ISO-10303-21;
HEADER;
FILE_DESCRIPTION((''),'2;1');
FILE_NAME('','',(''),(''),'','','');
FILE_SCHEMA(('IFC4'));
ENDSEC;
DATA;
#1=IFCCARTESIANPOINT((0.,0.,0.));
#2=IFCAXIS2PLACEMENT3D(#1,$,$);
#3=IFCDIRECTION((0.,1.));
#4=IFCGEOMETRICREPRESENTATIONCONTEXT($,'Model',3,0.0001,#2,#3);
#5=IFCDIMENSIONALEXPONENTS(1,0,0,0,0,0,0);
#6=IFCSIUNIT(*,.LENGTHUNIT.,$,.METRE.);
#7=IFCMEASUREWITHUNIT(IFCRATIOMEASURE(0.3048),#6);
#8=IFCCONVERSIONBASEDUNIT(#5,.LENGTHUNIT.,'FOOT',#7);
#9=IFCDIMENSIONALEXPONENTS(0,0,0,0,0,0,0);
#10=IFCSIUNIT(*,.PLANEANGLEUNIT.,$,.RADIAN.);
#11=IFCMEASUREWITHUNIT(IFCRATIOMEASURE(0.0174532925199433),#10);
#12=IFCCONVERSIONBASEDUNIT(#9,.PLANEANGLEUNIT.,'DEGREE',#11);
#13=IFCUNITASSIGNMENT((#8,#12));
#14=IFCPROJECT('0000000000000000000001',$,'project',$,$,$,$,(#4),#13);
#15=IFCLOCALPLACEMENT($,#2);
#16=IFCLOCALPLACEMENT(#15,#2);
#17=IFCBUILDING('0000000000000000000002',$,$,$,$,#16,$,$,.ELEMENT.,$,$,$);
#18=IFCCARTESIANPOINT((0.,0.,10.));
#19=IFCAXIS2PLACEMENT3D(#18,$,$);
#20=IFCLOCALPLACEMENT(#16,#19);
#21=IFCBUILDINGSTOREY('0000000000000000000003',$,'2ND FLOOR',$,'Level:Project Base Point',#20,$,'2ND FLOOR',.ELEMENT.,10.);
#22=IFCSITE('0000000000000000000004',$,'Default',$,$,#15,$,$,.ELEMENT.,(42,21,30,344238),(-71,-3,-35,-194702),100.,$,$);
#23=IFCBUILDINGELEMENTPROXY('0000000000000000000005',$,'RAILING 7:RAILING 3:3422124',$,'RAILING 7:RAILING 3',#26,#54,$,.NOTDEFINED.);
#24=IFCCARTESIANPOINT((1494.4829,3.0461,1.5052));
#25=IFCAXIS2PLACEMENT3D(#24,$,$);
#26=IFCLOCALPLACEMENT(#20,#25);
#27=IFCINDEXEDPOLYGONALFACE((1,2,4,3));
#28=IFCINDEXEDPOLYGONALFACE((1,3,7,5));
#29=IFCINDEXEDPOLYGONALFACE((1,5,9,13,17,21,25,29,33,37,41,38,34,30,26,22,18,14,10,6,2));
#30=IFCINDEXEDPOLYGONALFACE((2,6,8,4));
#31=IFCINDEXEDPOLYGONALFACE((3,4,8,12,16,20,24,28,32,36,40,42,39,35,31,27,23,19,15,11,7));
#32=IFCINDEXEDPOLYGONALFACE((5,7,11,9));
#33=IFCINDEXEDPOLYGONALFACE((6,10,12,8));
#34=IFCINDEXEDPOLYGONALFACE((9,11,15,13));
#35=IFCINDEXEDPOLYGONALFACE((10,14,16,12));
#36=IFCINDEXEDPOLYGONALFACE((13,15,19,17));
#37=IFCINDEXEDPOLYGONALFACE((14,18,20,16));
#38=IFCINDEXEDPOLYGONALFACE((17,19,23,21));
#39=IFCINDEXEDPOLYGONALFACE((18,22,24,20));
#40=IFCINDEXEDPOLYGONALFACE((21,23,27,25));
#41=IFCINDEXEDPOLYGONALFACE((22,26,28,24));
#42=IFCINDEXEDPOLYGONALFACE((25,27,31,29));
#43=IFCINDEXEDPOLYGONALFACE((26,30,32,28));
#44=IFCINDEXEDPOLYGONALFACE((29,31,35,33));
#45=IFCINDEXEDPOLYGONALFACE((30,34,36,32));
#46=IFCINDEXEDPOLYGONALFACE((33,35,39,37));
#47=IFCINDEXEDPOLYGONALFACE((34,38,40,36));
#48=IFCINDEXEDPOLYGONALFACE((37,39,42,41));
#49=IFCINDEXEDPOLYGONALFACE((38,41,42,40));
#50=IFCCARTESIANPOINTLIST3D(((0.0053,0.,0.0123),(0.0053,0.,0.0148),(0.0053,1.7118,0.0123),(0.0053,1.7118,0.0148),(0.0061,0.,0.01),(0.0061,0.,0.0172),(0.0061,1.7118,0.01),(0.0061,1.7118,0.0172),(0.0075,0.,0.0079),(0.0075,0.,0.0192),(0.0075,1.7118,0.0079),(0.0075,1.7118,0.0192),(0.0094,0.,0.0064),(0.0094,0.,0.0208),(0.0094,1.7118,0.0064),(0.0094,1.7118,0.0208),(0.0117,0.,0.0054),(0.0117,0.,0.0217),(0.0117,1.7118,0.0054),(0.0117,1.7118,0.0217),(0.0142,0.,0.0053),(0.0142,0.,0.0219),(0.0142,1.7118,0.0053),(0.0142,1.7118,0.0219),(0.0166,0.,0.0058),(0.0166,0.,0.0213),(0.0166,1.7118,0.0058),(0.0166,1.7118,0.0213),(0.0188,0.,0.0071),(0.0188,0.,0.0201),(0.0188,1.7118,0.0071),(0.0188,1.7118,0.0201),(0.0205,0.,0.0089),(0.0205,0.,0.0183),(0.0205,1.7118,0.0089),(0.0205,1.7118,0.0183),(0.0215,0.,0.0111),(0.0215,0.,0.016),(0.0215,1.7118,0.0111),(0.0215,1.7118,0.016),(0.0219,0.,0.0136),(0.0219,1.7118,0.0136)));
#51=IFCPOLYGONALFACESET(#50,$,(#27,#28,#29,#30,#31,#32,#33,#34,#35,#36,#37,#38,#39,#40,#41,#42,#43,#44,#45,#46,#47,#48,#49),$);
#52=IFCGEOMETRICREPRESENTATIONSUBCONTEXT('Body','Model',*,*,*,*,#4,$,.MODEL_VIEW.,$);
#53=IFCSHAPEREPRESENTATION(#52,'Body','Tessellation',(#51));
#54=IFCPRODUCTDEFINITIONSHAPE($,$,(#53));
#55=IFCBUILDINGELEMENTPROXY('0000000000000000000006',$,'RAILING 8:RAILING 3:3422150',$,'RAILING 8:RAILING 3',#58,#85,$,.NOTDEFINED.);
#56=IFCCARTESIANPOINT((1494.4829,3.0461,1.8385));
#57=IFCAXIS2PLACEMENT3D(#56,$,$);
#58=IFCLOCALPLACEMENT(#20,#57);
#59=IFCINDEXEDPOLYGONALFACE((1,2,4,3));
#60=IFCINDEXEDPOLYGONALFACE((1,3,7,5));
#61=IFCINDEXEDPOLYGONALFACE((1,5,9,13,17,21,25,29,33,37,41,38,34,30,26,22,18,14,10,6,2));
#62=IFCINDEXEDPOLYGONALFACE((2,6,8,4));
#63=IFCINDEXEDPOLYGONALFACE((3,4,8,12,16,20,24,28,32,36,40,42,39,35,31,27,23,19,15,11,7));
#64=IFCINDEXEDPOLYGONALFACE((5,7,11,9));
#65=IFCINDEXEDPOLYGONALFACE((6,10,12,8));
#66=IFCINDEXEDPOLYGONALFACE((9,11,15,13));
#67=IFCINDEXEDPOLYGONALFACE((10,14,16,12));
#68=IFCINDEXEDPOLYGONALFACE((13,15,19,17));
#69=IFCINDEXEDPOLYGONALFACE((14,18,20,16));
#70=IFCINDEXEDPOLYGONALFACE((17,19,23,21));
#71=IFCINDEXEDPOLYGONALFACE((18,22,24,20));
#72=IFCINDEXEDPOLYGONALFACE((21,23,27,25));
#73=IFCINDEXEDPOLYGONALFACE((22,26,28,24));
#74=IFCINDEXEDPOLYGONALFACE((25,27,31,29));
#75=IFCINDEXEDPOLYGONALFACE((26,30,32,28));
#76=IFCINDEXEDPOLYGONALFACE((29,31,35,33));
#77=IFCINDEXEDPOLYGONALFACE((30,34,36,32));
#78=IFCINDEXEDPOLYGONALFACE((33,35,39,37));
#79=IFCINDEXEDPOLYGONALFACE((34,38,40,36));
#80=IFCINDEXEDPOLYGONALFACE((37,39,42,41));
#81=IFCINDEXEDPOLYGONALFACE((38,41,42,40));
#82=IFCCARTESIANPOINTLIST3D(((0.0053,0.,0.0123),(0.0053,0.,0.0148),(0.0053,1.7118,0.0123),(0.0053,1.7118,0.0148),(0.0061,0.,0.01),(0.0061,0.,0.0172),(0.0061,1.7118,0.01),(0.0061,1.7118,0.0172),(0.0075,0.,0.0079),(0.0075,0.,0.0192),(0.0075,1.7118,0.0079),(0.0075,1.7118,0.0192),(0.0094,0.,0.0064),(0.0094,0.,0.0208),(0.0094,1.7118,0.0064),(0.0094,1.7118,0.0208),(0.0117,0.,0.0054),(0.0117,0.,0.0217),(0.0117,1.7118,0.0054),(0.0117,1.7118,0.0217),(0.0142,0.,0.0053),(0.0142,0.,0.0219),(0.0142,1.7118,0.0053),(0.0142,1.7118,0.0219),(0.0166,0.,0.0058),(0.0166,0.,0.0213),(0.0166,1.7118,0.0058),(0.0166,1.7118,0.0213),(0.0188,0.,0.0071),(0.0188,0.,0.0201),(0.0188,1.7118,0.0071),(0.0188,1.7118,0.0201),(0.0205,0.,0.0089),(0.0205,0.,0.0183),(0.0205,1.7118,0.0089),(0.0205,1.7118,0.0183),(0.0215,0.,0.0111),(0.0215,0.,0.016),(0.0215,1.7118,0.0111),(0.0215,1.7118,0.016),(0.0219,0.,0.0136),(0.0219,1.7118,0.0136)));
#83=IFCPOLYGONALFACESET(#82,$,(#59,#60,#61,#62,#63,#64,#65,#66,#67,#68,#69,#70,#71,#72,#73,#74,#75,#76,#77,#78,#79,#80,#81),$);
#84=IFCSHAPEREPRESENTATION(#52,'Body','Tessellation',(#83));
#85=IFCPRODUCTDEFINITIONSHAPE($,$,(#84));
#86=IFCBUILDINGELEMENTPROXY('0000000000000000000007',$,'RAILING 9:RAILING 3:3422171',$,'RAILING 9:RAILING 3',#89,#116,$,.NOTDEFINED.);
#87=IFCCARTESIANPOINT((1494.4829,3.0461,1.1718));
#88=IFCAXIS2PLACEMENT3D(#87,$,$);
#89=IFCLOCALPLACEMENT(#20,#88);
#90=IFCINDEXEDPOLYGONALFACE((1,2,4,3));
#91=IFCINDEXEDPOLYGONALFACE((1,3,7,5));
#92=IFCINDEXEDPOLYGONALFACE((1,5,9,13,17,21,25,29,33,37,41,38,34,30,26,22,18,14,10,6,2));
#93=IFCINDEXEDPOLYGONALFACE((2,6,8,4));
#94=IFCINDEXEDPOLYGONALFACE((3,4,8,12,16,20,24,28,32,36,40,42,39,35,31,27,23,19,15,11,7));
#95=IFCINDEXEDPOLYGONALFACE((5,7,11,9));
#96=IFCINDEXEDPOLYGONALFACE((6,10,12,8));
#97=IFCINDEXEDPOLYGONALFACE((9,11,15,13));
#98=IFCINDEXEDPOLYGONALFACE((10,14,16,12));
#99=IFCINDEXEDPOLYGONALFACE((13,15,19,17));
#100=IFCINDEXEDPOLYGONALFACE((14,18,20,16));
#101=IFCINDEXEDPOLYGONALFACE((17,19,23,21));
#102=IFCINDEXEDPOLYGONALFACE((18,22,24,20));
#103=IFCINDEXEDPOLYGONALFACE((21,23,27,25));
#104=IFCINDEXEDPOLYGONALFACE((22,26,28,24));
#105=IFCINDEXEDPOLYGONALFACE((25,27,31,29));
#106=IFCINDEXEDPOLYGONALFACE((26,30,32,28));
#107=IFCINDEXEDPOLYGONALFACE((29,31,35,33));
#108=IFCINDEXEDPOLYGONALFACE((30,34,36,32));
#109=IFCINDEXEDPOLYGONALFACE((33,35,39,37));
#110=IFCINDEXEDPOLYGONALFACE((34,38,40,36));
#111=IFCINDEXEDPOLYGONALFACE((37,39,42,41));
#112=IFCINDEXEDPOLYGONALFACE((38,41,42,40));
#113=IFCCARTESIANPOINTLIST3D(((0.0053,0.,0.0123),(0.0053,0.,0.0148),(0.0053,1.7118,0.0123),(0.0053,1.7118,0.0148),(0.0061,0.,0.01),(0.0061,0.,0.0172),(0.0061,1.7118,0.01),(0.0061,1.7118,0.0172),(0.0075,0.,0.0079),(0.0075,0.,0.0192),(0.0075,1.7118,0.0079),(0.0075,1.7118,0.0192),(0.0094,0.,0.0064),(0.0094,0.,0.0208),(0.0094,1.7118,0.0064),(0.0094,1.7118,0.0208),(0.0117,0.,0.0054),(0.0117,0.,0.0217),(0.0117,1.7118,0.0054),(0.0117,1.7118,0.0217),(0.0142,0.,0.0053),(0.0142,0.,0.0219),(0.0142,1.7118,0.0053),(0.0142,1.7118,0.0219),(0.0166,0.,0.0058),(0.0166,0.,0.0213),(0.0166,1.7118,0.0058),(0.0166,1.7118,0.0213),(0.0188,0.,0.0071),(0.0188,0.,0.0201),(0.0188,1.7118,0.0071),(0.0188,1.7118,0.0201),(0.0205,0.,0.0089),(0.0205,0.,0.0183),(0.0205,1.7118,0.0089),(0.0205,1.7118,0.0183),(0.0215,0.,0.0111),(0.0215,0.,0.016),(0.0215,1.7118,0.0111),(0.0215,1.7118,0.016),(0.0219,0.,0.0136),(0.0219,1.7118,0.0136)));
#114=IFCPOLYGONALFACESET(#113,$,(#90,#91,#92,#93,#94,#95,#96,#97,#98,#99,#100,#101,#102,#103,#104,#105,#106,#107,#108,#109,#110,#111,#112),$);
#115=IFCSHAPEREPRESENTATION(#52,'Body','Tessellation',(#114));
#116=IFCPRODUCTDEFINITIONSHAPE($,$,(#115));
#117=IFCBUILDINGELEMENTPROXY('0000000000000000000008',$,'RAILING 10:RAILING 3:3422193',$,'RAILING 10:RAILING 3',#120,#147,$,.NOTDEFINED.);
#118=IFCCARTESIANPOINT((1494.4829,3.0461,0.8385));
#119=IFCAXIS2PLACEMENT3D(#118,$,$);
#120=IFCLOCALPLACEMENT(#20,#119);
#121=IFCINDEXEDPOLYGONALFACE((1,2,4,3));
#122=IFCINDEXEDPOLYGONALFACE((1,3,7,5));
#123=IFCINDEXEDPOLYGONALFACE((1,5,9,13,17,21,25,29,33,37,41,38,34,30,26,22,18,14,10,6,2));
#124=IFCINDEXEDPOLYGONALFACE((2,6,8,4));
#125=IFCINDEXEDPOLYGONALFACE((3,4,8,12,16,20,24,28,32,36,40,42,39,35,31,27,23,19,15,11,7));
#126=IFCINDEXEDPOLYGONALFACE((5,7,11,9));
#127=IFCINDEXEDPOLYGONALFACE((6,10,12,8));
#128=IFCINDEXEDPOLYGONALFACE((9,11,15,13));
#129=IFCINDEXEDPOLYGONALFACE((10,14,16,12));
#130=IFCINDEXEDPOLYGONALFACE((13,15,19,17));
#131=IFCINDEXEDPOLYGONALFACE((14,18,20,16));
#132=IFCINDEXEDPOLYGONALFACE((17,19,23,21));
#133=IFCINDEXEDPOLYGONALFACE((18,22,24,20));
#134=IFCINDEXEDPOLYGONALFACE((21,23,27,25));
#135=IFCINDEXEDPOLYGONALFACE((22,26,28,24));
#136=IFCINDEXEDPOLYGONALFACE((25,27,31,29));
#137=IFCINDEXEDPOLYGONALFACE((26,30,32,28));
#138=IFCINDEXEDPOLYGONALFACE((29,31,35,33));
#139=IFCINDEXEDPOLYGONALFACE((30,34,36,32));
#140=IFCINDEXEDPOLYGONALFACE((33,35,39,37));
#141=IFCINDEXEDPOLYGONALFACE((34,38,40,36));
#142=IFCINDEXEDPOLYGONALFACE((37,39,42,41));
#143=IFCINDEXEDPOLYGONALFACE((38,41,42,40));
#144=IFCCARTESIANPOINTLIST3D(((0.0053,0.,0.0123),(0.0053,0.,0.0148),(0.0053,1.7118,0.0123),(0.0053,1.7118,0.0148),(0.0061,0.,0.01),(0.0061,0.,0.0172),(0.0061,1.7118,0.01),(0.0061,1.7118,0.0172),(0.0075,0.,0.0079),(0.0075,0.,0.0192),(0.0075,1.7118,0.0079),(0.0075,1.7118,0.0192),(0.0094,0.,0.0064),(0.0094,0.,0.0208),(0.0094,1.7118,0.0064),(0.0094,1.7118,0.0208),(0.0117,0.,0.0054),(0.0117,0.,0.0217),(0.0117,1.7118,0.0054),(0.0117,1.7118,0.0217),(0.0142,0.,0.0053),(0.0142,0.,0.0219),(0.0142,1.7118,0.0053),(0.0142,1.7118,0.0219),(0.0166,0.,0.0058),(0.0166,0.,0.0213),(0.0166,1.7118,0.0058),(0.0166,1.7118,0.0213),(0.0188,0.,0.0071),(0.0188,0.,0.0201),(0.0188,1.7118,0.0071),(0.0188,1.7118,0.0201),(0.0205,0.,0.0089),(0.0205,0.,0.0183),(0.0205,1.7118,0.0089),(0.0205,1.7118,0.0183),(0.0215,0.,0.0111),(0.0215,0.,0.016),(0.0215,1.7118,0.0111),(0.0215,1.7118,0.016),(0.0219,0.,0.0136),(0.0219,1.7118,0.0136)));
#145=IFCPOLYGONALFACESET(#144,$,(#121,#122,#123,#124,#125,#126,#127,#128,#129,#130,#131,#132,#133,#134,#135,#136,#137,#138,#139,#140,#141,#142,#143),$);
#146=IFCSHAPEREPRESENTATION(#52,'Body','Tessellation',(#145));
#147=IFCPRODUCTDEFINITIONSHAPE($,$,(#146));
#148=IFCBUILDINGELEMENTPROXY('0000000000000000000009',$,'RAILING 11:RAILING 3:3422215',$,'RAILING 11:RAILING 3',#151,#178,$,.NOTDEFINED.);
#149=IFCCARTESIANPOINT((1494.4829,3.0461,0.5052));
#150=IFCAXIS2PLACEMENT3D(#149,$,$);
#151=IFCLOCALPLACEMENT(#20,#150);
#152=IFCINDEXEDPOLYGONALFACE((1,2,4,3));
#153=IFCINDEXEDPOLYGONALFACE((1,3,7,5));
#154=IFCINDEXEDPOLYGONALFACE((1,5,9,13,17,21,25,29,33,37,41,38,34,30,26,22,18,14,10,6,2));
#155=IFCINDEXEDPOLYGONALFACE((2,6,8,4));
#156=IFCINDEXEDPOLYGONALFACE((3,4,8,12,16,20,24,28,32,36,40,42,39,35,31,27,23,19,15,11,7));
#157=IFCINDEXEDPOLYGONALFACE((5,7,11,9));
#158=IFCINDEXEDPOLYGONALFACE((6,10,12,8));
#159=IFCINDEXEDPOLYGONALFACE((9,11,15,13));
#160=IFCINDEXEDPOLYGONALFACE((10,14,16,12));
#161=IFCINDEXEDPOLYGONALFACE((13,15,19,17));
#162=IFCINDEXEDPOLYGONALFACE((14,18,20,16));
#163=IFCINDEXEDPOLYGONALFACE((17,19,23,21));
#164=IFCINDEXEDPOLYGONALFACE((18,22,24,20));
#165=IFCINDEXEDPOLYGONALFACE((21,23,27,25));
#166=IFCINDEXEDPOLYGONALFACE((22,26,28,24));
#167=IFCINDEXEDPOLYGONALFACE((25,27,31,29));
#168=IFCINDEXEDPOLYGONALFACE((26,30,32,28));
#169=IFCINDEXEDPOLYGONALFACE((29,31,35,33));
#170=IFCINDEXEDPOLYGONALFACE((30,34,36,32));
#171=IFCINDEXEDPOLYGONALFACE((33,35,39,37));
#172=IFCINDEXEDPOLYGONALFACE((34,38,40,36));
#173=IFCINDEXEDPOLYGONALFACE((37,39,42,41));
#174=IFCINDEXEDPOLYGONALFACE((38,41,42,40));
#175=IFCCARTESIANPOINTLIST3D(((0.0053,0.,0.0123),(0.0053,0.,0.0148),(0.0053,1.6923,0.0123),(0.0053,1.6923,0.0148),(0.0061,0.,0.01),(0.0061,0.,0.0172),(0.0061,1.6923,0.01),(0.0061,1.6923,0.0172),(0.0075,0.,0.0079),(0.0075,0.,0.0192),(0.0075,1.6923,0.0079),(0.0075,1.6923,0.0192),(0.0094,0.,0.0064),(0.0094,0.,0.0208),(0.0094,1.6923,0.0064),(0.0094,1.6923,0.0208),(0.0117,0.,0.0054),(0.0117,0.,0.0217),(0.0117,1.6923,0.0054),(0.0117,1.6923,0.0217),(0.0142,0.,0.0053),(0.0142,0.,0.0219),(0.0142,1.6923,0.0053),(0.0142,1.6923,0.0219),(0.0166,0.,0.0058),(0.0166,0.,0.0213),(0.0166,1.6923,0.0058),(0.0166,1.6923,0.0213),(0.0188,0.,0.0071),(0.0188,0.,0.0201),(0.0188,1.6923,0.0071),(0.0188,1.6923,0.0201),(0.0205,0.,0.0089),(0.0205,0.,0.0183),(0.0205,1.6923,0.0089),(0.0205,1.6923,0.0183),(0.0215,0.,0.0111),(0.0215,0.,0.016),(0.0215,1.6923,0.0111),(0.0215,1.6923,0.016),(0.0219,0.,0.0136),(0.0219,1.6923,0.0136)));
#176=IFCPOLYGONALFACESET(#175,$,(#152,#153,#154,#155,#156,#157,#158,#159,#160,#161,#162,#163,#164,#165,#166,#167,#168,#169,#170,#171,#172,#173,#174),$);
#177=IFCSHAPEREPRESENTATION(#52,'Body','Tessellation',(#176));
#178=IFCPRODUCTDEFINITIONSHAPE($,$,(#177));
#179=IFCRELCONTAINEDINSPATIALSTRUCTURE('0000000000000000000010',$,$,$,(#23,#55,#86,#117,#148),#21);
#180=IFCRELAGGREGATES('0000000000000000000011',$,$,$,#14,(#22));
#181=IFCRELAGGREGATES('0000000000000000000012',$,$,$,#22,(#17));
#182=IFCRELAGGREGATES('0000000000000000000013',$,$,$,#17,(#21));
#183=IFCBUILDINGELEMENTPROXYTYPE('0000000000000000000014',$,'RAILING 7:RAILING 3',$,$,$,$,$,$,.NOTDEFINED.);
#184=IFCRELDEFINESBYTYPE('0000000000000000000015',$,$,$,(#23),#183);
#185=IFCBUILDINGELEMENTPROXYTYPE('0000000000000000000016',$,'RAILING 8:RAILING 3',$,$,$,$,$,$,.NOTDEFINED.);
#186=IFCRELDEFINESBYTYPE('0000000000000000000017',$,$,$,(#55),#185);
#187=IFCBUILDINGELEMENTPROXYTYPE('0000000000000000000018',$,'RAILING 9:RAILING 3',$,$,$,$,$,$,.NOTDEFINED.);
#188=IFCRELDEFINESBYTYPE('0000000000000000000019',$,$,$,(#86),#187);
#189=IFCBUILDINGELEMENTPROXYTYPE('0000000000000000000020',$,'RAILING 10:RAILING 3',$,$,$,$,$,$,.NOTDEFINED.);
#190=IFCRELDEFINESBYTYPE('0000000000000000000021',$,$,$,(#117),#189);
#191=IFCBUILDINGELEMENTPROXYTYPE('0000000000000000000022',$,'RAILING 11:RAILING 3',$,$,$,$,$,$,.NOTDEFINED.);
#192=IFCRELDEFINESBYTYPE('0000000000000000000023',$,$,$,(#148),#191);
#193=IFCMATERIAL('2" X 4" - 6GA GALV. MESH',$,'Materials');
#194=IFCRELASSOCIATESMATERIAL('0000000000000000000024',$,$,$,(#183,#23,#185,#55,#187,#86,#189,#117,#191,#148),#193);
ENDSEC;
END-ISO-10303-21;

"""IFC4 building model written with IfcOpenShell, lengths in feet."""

from ifc_helpers import new_model, entity, si_unit, converted_unit, direction, frame, origin, origin_2d_with_axis, place, context, subcontext, project, spatial, circle, extrude, source, transform, mapped, material, type_object, type_shapes, element, save


model = new_model("IFC4")

# Units and contexts
model_context = context("Model", 3, precision=0.0001, world=origin(), true_north=direction((0.0, 1.0)))
body_context = subcontext(model_context, "Body", "Model", "MODEL_VIEW")
ifc_project = project(units=[converted_unit("LENGTHUNIT", "FOOT", entity("IfcRatioMeasure", 0.3048), si_unit("LENGTHUNIT", "METRE"), dimensions=[1, 0, 0, 0, 0, 0, 0]), converted_unit("PLANEANGLEUNIT", "DEGREE", entity("IfcRatioMeasure", 0.0174532925199433), si_unit("PLANEANGLEUNIT", "RADIAN"), dimensions=[0, 0, 0, 0, 0, 0, 0])], contexts=[model_context])

# Site, building, storey
site_placement = place(None, origin())
site = spatial("IfcSite", under=ifc_project, at=site_placement, Name="Default", CompositionType="ELEMENT", RefLatitude=(42, 21, 30, 344238), RefLongitude=(-71, -3, -35, -194702), RefElevation=100.0)
building_placement = place(site_placement, origin())
building = spatial("IfcBuilding", under=site, at=building_placement, CompositionType="ELEMENT")
storey_placement = place(building_placement, frame((0.0, 0.0, 10.0)))
storey = spatial("IfcBuildingStorey", under=building, at=storey_placement, Name="2ND FLOOR", ObjectType="Level:Project Base Point", LongName="2ND FLOOR", CompositionType="ELEMENT", Elevation=10.0)

# Building element proxies
ifc_material_1 = material(Name="2\" X 4\" - 6GA GALV. MESH", Category="Materials")
building_element_proxy_type_1 = type_object("IfcBuildingElementProxyType", Name="RAILING 7:RAILING 3", PredefinedType="NOTDEFINED", material=ifc_material_1)
shared_shape_1 = source(origin(), body_context, "Body", "SweptSolid", [
    extrude(circle(Radius=0.0083, at=origin_2d_with_axis()), frame((0.0136, 0.0, 0.0136), z_axis=(0.0, 1.0, 0.0), x_axis=(1.0, 0.0, 0.0)), (0.0, 0.0, 1.0), 1.7118),
])
type_shapes(building_element_proxy_type_1, [shared_shape_1])
proxy_1_placement = place(storey_placement, frame((1494.4829, 3.0461, 1.5052)))
element("IfcBuildingElementProxy", 1, at=proxy_1_placement, inside=storey, type_object=building_element_proxy_type_1, material=ifc_material_1, Name="RAILING 7:RAILING 3:3422124", ObjectType="RAILING 7:RAILING 3", PredefinedType="NOTDEFINED", context=body_context, shape_type="MappedRepresentation", body=[
    mapped(shared_shape_1, transform((0.0, 0.0, 0.0), scale=1.0)),
])
building_element_proxy_type_2 = type_object("IfcBuildingElementProxyType", Name="RAILING 8:RAILING 3", PredefinedType="NOTDEFINED", material=ifc_material_1)
shared_shape_2 = source(origin(), body_context, "Body", "SweptSolid", [
    extrude(circle(Radius=0.0083, at=origin_2d_with_axis()), frame((0.0136, 0.0, 0.0136), z_axis=(0.0, 1.0, 0.0), x_axis=(1.0, 0.0, 0.0)), (0.0, 0.0, 1.0), 1.7118),
])
type_shapes(building_element_proxy_type_2, [shared_shape_2])
proxy_2_placement = place(storey_placement, frame((1494.4829, 3.0461, 1.8385)))
element("IfcBuildingElementProxy", 2, at=proxy_2_placement, inside=storey, type_object=building_element_proxy_type_2, material=ifc_material_1, Name="RAILING 8:RAILING 3:3422150", ObjectType="RAILING 8:RAILING 3", PredefinedType="NOTDEFINED", context=body_context, shape_type="MappedRepresentation", body=[
    mapped(shared_shape_2, transform((0.0, 0.0, 0.0), scale=1.0)),
])
building_element_proxy_type_3 = type_object("IfcBuildingElementProxyType", Name="RAILING 9:RAILING 3", PredefinedType="NOTDEFINED", material=ifc_material_1)
shared_shape_3 = source(origin(), body_context, "Body", "SweptSolid", [
    extrude(circle(Radius=0.0083, at=origin_2d_with_axis()), frame((0.0136, 0.0, 0.0136), z_axis=(0.0, 1.0, 0.0), x_axis=(1.0, 0.0, 0.0)), (0.0, 0.0, 1.0), 1.7118),
])
type_shapes(building_element_proxy_type_3, [shared_shape_3])
proxy_3_placement = place(storey_placement, frame((1494.4829, 3.0461, 1.1718)))
element("IfcBuildingElementProxy", 3, at=proxy_3_placement, inside=storey, type_object=building_element_proxy_type_3, material=ifc_material_1, Name="RAILING 9:RAILING 3:3422171", ObjectType="RAILING 9:RAILING 3", PredefinedType="NOTDEFINED", context=body_context, shape_type="MappedRepresentation", body=[
    mapped(shared_shape_3, transform((0.0, 0.0, 0.0), scale=1.0)),
])
building_element_proxy_type_4 = type_object("IfcBuildingElementProxyType", Name="RAILING 10:RAILING 3", PredefinedType="NOTDEFINED", material=ifc_material_1)
shared_shape_4 = source(origin(), body_context, "Body", "SweptSolid", [
    extrude(circle(Radius=0.0083, at=origin_2d_with_axis()), frame((0.0136, 0.0, 0.0136), z_axis=(0.0, 1.0, 0.0), x_axis=(1.0, 0.0, 0.0)), (0.0, 0.0, 1.0), 1.7118),
])
type_shapes(building_element_proxy_type_4, [shared_shape_4])
proxy_4_placement = place(storey_placement, frame((1494.4829, 3.0461, 0.8385)))
element("IfcBuildingElementProxy", 4, at=proxy_4_placement, inside=storey, type_object=building_element_proxy_type_4, material=ifc_material_1, Name="RAILING 10:RAILING 3:3422193", ObjectType="RAILING 10:RAILING 3", PredefinedType="NOTDEFINED", context=body_context, shape_type="MappedRepresentation", body=[
    mapped(shared_shape_4, transform((0.0, 0.0, 0.0), scale=1.0)),
])
building_element_proxy_type_5 = type_object("IfcBuildingElementProxyType", Name="RAILING 11:RAILING 3", PredefinedType="NOTDEFINED", material=ifc_material_1)
shared_shape_5 = source(origin(), body_context, "Body", "SweptSolid", [
    extrude(circle(Radius=0.0083, at=origin_2d_with_axis()), frame((0.0136, 0.0, 0.0136), z_axis=(0.0, 1.0, 0.0), x_axis=(1.0, 0.0, 0.0)), (0.0, 0.0, 1.0), 1.6923),
])
type_shapes(building_element_proxy_type_5, [shared_shape_5])
proxy_5_placement = place(storey_placement, frame((1494.4829, 3.0461, 0.5052)))
element("IfcBuildingElementProxy", 5, at=proxy_5_placement, inside=storey, type_object=building_element_proxy_type_5, material=ifc_material_1, Name="RAILING 11:RAILING 3:3422215", ObjectType="RAILING 11:RAILING 3", PredefinedType="NOTDEFINED", context=body_context, shape_type="MappedRepresentation", body=[
    mapped(shared_shape_5, transform((0.0, 0.0, 0.0), scale=1.0)),
])

save(model, "model.ifc")
